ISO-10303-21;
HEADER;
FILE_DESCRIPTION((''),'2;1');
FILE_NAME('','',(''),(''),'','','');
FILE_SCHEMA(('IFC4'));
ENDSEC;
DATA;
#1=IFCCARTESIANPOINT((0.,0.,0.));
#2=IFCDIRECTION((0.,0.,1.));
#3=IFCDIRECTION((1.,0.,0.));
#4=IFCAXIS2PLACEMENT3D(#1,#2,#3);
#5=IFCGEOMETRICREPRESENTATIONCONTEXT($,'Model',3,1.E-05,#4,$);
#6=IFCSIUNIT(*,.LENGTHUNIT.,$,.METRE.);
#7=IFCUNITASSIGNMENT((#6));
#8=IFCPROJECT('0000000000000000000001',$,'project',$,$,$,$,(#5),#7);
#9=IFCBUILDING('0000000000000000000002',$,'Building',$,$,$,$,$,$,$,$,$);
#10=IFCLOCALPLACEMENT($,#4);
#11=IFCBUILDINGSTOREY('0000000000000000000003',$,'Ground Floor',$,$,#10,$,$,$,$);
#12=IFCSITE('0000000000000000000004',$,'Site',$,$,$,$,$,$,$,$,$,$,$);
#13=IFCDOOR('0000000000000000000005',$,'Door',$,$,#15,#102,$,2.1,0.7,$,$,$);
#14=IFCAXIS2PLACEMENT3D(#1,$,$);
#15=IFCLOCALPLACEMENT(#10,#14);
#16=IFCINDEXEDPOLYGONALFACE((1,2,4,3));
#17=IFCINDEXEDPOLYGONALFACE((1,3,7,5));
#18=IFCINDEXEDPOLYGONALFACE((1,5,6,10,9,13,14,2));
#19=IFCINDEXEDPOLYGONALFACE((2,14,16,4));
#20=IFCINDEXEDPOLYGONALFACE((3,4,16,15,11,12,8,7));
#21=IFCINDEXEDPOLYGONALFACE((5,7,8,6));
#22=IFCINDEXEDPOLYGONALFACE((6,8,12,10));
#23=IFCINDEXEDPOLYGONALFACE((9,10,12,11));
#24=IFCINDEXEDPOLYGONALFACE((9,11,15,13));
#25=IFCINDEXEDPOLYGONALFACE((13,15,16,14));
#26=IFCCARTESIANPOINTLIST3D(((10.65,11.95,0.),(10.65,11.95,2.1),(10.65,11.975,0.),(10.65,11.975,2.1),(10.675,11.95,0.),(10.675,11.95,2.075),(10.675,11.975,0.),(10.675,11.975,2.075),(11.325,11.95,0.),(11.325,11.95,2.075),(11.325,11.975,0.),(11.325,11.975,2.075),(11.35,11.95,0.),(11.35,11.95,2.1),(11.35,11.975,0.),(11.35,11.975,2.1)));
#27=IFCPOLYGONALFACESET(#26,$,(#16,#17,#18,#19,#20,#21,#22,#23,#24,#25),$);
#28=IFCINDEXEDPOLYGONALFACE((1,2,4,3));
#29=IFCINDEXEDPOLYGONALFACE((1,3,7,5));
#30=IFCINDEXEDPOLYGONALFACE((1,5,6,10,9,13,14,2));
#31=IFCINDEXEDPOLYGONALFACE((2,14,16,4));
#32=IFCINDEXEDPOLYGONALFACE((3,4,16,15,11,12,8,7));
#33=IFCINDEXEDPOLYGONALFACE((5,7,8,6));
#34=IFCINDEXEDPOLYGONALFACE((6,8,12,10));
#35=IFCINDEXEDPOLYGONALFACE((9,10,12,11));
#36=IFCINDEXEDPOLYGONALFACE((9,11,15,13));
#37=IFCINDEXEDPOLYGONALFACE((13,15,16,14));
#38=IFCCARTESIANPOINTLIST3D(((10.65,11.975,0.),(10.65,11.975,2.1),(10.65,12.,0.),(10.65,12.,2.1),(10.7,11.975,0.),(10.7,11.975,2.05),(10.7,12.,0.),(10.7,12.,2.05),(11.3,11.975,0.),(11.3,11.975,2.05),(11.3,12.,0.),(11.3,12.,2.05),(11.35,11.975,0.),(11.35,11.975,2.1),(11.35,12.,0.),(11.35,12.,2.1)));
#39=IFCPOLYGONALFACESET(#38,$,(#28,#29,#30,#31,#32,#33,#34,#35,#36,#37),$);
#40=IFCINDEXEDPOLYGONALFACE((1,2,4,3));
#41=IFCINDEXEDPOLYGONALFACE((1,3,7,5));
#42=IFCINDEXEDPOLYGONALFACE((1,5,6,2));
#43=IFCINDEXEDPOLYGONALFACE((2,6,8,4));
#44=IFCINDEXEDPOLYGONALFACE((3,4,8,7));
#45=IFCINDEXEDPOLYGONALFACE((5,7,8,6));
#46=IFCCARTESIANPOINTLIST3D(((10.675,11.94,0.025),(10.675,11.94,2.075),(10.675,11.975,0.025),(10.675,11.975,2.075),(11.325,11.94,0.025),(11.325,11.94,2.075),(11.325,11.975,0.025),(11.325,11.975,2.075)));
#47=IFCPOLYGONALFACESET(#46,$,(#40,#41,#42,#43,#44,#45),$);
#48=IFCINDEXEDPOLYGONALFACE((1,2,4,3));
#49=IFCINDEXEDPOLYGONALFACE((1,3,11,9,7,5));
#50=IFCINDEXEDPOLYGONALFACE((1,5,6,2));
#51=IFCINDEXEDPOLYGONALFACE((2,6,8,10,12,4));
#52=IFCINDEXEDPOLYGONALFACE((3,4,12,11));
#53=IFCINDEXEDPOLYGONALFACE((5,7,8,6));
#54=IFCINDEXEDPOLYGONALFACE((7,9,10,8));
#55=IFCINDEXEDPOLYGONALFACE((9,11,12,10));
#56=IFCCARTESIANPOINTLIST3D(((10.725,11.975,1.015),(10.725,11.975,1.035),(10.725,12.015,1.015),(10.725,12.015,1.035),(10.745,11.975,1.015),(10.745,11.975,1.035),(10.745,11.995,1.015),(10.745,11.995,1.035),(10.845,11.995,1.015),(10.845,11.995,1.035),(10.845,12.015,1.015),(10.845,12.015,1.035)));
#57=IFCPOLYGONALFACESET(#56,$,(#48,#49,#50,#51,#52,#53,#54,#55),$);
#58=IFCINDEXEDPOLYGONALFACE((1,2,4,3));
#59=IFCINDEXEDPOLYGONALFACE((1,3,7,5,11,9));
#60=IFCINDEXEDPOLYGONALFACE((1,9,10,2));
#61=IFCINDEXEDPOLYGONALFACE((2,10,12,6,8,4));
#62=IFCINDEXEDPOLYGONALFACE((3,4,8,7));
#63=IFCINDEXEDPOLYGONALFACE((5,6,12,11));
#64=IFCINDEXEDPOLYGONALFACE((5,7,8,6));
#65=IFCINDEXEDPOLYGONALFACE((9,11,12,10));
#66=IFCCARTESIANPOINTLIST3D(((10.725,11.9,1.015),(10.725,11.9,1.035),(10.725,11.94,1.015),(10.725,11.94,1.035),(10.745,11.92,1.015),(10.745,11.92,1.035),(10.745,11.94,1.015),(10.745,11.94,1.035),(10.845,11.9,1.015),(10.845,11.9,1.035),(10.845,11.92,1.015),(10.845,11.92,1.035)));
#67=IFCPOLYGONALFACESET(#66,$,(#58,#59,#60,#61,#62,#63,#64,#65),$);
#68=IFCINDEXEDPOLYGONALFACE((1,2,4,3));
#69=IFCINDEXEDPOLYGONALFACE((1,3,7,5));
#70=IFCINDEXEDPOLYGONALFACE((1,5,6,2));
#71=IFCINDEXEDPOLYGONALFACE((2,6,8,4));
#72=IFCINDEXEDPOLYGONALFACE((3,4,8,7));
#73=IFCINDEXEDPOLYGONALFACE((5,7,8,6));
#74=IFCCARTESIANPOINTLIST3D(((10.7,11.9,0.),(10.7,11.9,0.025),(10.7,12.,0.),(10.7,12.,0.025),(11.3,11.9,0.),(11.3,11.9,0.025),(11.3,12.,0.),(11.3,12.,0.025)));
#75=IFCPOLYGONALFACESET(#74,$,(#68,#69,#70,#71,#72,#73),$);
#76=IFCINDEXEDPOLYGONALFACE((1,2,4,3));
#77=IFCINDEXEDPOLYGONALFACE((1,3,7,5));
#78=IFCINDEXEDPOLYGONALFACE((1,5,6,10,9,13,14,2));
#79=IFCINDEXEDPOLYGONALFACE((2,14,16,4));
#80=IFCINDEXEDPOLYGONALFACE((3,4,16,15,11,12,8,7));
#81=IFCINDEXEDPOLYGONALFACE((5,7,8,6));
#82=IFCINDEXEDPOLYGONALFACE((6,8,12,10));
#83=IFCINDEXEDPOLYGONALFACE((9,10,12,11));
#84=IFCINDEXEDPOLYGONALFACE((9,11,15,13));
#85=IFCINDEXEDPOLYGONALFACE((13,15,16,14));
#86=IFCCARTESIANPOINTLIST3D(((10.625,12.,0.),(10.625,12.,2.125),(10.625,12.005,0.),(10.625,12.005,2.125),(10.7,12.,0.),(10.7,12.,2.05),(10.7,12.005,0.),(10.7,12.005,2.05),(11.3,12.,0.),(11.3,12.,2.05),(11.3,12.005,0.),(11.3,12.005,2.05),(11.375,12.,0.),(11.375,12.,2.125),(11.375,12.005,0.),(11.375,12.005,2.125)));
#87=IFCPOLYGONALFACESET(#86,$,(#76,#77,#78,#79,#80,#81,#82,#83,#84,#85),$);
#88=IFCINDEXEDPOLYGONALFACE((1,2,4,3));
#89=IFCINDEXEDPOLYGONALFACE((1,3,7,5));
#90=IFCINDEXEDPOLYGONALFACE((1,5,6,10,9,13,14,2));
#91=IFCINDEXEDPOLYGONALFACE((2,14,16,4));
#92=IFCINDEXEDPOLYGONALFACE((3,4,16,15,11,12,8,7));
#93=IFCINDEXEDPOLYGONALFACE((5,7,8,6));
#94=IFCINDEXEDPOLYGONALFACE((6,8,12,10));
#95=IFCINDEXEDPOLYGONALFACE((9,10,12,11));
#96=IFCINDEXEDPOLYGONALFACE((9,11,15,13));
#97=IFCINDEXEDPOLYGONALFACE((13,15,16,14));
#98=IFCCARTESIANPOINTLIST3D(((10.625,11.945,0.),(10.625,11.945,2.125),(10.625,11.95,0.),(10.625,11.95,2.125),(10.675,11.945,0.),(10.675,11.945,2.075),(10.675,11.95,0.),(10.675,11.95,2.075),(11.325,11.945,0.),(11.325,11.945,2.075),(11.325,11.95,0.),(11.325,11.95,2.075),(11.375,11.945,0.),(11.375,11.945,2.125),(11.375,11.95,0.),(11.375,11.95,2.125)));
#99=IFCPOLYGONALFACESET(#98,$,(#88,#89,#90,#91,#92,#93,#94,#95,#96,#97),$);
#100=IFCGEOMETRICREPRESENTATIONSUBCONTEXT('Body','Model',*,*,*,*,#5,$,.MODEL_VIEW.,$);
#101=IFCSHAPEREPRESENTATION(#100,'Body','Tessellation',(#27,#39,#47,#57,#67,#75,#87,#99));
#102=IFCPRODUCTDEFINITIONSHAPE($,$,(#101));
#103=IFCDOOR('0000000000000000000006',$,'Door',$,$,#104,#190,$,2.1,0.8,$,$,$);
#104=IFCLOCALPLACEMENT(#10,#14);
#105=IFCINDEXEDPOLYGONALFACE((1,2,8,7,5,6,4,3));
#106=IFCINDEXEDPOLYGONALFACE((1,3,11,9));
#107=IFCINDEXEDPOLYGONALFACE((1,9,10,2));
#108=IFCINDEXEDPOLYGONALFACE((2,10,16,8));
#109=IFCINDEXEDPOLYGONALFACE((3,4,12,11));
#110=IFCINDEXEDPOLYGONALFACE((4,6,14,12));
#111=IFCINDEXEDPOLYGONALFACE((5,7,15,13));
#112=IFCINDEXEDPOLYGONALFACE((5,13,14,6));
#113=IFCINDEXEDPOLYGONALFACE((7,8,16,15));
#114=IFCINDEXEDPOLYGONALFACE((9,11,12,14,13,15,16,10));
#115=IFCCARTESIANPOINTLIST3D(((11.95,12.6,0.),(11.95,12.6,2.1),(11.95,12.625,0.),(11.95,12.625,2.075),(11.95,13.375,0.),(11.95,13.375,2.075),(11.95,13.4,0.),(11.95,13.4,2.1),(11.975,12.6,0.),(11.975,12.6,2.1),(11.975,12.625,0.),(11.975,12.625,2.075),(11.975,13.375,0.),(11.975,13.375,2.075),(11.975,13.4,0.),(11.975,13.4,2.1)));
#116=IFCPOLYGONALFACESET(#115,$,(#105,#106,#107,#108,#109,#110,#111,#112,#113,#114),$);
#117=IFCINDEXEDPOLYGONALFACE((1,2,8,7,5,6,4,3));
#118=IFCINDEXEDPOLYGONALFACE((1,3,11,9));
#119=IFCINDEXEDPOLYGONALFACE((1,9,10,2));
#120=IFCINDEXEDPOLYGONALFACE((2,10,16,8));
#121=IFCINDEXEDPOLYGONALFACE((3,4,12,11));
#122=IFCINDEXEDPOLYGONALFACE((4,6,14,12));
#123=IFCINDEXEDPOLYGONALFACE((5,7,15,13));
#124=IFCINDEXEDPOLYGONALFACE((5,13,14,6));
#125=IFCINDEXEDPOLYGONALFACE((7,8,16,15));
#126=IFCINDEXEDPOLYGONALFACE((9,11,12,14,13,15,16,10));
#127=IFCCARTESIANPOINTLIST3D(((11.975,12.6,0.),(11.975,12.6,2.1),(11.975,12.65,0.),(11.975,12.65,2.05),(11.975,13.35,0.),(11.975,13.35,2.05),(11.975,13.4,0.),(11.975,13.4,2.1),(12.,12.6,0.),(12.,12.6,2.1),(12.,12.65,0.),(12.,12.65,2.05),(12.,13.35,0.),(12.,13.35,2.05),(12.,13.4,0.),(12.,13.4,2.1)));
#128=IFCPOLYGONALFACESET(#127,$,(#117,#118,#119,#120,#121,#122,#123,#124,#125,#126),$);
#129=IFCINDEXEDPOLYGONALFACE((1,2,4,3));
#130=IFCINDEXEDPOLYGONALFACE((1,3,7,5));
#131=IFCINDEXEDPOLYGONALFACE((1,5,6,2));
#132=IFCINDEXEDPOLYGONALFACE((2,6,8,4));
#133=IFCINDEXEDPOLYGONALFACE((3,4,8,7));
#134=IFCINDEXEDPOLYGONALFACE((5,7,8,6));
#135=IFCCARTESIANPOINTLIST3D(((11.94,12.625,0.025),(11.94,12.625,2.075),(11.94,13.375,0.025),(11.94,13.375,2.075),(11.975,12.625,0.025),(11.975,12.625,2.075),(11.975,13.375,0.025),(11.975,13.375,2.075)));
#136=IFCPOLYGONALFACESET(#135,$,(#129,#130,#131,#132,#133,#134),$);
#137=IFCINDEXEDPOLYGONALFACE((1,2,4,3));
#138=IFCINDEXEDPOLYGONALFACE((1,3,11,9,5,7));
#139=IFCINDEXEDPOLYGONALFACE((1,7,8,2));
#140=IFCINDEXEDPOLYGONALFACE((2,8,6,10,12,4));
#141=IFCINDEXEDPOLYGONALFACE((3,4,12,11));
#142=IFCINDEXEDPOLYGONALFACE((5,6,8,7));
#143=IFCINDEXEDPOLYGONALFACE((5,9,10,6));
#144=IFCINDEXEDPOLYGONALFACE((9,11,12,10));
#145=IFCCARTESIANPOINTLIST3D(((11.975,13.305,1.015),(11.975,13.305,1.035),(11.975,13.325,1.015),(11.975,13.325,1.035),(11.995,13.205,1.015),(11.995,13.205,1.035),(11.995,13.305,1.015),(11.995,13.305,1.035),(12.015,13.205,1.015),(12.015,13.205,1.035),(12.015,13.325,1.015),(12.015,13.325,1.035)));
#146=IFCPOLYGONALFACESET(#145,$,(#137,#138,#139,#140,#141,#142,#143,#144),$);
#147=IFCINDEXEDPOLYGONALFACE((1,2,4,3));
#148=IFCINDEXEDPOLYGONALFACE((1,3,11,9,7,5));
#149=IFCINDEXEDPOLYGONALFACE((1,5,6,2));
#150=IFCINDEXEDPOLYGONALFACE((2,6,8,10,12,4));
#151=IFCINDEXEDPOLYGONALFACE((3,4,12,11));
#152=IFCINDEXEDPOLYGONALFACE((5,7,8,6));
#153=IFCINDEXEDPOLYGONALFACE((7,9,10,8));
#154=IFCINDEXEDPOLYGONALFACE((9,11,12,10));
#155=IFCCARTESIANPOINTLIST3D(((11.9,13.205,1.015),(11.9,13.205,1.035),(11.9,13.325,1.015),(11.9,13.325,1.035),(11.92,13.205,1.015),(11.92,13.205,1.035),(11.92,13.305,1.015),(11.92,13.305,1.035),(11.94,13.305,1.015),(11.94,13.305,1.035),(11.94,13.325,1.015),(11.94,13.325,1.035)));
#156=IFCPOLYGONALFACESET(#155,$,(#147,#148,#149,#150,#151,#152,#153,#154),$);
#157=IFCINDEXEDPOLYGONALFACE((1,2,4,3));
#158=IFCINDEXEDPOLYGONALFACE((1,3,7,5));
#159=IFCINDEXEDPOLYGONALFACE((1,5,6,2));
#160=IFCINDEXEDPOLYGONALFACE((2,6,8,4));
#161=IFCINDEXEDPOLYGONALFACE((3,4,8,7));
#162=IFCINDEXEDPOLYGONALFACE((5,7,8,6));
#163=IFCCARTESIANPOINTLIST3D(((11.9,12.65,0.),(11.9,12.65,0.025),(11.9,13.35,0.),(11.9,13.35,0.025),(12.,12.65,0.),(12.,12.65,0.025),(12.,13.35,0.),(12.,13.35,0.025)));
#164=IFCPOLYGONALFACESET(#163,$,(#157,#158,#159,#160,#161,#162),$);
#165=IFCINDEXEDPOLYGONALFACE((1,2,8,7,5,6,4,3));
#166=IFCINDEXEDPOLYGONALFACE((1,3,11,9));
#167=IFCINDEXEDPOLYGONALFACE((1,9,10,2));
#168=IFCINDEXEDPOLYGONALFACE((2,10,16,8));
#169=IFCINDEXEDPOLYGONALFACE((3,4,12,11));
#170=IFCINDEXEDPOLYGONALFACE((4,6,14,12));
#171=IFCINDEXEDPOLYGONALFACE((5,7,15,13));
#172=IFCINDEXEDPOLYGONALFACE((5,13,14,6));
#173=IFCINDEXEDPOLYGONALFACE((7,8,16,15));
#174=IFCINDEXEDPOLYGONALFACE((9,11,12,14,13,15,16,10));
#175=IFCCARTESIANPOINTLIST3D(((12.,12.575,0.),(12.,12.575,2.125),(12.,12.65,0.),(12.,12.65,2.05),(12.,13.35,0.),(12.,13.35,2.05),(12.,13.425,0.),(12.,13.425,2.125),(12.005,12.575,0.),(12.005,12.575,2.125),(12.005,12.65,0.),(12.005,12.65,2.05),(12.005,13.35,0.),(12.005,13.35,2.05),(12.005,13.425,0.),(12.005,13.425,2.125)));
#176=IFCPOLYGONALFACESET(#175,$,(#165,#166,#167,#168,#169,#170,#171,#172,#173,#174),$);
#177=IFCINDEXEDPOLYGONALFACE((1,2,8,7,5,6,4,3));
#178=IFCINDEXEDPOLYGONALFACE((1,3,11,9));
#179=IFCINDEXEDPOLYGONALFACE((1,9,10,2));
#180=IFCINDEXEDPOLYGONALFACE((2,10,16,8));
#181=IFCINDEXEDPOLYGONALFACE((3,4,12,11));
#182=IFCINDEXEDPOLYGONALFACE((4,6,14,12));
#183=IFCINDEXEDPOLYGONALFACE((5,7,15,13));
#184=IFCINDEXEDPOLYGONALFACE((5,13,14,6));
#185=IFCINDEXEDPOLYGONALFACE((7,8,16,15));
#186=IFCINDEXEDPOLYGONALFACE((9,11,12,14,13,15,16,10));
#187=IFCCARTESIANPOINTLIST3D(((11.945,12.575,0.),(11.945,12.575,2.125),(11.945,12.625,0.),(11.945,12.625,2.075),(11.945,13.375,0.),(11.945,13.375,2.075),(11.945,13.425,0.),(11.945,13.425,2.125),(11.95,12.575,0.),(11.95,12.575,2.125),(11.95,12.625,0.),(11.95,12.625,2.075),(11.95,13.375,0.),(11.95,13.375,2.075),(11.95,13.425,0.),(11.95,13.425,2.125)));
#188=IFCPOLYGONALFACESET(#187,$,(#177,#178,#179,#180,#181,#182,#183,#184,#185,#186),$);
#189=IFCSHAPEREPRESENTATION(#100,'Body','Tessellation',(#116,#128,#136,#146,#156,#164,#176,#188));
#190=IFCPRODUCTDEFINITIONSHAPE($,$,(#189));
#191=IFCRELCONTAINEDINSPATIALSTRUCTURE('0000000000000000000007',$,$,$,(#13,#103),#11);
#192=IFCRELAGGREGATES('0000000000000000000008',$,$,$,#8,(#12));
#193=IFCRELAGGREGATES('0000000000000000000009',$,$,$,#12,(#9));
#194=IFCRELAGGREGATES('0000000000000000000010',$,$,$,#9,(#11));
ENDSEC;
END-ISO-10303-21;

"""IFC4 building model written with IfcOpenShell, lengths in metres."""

from ifc_helpers import new_model, si_unit, frame, origin_with_axes, place, context, subcontext, project, spatial, line, indexed_curve, outline, extrude, element, save


model = new_model("IFC4")

# Units and contexts
model_context = context("Model", 3, precision=1e-05, world=origin_with_axes())
body_context = subcontext(model_context, "Body", "Model", "MODEL_VIEW")
ifc_project = project(units=[si_unit("LENGTHUNIT", "METRE")], contexts=[model_context])

# Site, building, storey
site = spatial("IfcSite", under=ifc_project, Name="Site")
building = spatial("IfcBuilding", under=site, Name="Building")
storey_placement = place(None, origin_with_axes())
storey = spatial("IfcBuildingStorey", under=building, at=storey_placement, Name="Ground Floor")

# Doors
door_1_placement = place(storey_placement, frame((11.35, 12.0, 0.0), z_axis=(0.0, 0.0, 1.0), x_axis=(-1.0, 0.0, 0.0)))
element("IfcDoor", 1, at=door_1_placement, inside=storey, Name="Door", OverallHeight=2.1, OverallWidth=0.7, context=body_context, shape_type="SweptSolid", body=[
    extrude(outline(indexed_curve([(0.0, 0.0), (0.0, 2.1), (0.7, 2.1), (0.7, 0.0), (0.675, 0.0), (0.675, 2.075), (0.025, 2.075), (0.025, 0.0)], segments=[line(1, 2, 3, 4, 5, 6, 7, 8, 1)])), frame((0.0, 0.025, 0.0), z_axis=(0.0, -1.0, 0.0), x_axis=(1.0, 0.0, 0.0)), (0.0, 0.0, -1.0), 0.025),
    extrude(outline(indexed_curve([(0.0, 0.0), (0.0, 2.1), (0.7, 2.1), (0.7, 0.0), (0.65, 0.0), (0.65, 2.05), (0.05, 2.05), (0.05, 0.0)], segments=[line(1, 2, 3, 4, 5, 6, 7, 8, 1)])), frame((0.0, 0.0, 0.0), z_axis=(0.0, -1.0, 0.0), x_axis=(1.0, 0.0, 0.0)), (0.0, 0.0, -1.0), 0.025),
    extrude(outline(indexed_curve([(0.0, 0.0), (0.65, 0.0), (0.65, 0.035), (0.0, 0.035)], segments=[line(1, 2, 3, 4, 1)])), frame((0.025, 0.025, 0.025), z_axis=(0.0, 0.0, 1.0), x_axis=(1.0, 0.0, 0.0)), (0.0, 0.0, 1.0), 2.05),
    extrude(outline(indexed_curve([(0.0, 0.0), (0.0, -0.04), (-0.12, -0.04), (-0.12, -0.02), (-0.02, -0.02), (-0.02, 0.0)], segments=[line(1, 2, 3, 4, 5, 6, 1)])), frame((0.625, 0.025, 1.015), z_axis=(0.0, 0.0, 1.0), x_axis=(1.0, 0.0, 0.0)), (0.0, 0.0, 1.0), 0.02),
    extrude(outline(indexed_curve([(0.0, 0.0), (0.0, 0.04), (-0.12, 0.04), (-0.12, 0.02), (-0.02, 0.02), (-0.02, 0.0)], segments=[line(1, 2, 3, 4, 5, 6, 1)])), frame((0.625, 0.06, 1.015), z_axis=(0.0, 0.0, 1.0), x_axis=(1.0, 0.0, 0.0)), (0.0, 0.0, 1.0), 0.02),
    extrude(outline(indexed_curve([(0.0, 0.0), (0.6, 0.0), (0.6, 0.1), (0.0, 0.1)], segments=[line(1, 2, 3, 4, 1)])), frame((0.05, 0.0, 0.0), z_axis=(0.0, 0.0, 1.0), x_axis=(1.0, 0.0, 0.0)), (0.0, 0.0, 1.0), 0.025),
    extrude(outline(indexed_curve([(0.0, 0.0), (0.0, 2.125), (0.75, 2.125), (0.75, 0.0), (0.675, 0.0), (0.675, 2.05), (0.075, 2.05), (0.075, 0.0)], segments=[line(1, 2, 3, 4, 5, 6, 7, 8, 1)])), frame((-0.025, -0.005, 0.0), z_axis=(0.0, -1.0, 0.0), x_axis=(1.0, 0.0, 0.0)), (0.0, 0.0, -1.0), 0.005),
    extrude(outline(indexed_curve([(0.0, 0.0), (0.0, 2.125), (0.75, 2.125), (0.75, 0.0), (0.7, 0.0), (0.7, 2.075), (0.05, 2.075), (0.05, 0.0)], segments=[line(1, 2, 3, 4, 5, 6, 7, 8, 1)])), frame((-0.025, 0.05, 0.0), z_axis=(0.0, -1.0, 0.0), x_axis=(1.0, 0.0, 0.0)), (0.0, 0.0, -1.0), 0.005),
])
door_2_placement = place(storey_placement, frame((12.0, 12.6, 0.0), z_axis=(0.0, 0.0, 1.0), x_axis=(0.0, 1.0, 0.0)))
element("IfcDoor", 2, at=door_2_placement, inside=storey, Name="Door", OverallHeight=2.1, OverallWidth=0.8, context=body_context, shape_type="SweptSolid", body=[
    extrude(outline(indexed_curve([(0.0, 0.0), (0.0, 2.1), (0.8, 2.1), (0.8, 0.0), (0.775, 0.0), (0.775, 2.075), (0.025, 2.075), (0.025, 0.0)], segments=[line(1, 2, 3, 4, 5, 6, 7, 8, 1)])), frame((0.0, 0.025, 0.0), z_axis=(0.0, -1.0, 0.0), x_axis=(1.0, 0.0, 0.0)), (0.0, 0.0, -1.0), 0.025),
    extrude(outline(indexed_curve([(0.0, 0.0), (0.0, 2.1), (0.8, 2.1), (0.8, 0.0), (0.75, 0.0), (0.75, 2.05), (0.05, 2.05), (0.05, 0.0)], segments=[line(1, 2, 3, 4, 5, 6, 7, 8, 1)])), frame((0.0, 0.0, 0.0), z_axis=(0.0, -1.0, 0.0), x_axis=(1.0, 0.0, 0.0)), (0.0, 0.0, -1.0), 0.025),
    extrude(outline(indexed_curve([(0.0, 0.0), (0.75, 0.0), (0.75, 0.035), (0.0, 0.035)], segments=[line(1, 2, 3, 4, 1)])), frame((0.025, 0.025, 0.025), z_axis=(0.0, 0.0, 1.0), x_axis=(1.0, 0.0, 0.0)), (0.0, 0.0, 1.0), 2.05),
    extrude(outline(indexed_curve([(0.0, 0.0), (0.0, -0.04), (-0.12, -0.04), (-0.12, -0.02), (-0.02, -0.02), (-0.02, 0.0)], segments=[line(1, 2, 3, 4, 5, 6, 1)])), frame((0.725, 0.025, 1.015), z_axis=(0.0, 0.0, 1.0), x_axis=(1.0, 0.0, 0.0)), (0.0, 0.0, 1.0), 0.02),
    extrude(outline(indexed_curve([(0.0, 0.0), (0.0, 0.04), (-0.12, 0.04), (-0.12, 0.02), (-0.02, 0.02), (-0.02, 0.0)], segments=[line(1, 2, 3, 4, 5, 6, 1)])), frame((0.725, 0.06, 1.015), z_axis=(0.0, 0.0, 1.0), x_axis=(1.0, 0.0, 0.0)), (0.0, 0.0, 1.0), 0.02),
    extrude(outline(indexed_curve([(0.0, 0.0), (0.7, 0.0), (0.7, 0.1), (0.0, 0.1)], segments=[line(1, 2, 3, 4, 1)])), frame((0.05, 0.0, 0.0), z_axis=(0.0, 0.0, 1.0), x_axis=(1.0, 0.0, 0.0)), (0.0, 0.0, 1.0), 0.025),
    extrude(outline(indexed_curve([(0.0, 0.0), (0.0, 2.125), (0.85, 2.125), (0.85, 0.0), (0.775, 0.0), (0.775, 2.05), (0.075, 2.05), (0.075, 0.0)], segments=[line(1, 2, 3, 4, 5, 6, 7, 8, 1)])), frame((-0.025, -0.005, 0.0), z_axis=(0.0, -1.0, 0.0), x_axis=(1.0, 0.0, 0.0)), (0.0, 0.0, -1.0), 0.005),
    extrude(outline(indexed_curve([(0.0, 0.0), (0.0, 2.125), (0.85, 2.125), (0.85, 0.0), (0.8, 0.0), (0.8, 2.075), (0.05, 2.075), (0.05, 0.0)], segments=[line(1, 2, 3, 4, 5, 6, 7, 8, 1)])), frame((-0.025, 0.05, 0.0), z_axis=(0.0, -1.0, 0.0), x_axis=(1.0, 0.0, 0.0)), (0.0, 0.0, -1.0), 0.005),
])

save(model, "model.ifc")
